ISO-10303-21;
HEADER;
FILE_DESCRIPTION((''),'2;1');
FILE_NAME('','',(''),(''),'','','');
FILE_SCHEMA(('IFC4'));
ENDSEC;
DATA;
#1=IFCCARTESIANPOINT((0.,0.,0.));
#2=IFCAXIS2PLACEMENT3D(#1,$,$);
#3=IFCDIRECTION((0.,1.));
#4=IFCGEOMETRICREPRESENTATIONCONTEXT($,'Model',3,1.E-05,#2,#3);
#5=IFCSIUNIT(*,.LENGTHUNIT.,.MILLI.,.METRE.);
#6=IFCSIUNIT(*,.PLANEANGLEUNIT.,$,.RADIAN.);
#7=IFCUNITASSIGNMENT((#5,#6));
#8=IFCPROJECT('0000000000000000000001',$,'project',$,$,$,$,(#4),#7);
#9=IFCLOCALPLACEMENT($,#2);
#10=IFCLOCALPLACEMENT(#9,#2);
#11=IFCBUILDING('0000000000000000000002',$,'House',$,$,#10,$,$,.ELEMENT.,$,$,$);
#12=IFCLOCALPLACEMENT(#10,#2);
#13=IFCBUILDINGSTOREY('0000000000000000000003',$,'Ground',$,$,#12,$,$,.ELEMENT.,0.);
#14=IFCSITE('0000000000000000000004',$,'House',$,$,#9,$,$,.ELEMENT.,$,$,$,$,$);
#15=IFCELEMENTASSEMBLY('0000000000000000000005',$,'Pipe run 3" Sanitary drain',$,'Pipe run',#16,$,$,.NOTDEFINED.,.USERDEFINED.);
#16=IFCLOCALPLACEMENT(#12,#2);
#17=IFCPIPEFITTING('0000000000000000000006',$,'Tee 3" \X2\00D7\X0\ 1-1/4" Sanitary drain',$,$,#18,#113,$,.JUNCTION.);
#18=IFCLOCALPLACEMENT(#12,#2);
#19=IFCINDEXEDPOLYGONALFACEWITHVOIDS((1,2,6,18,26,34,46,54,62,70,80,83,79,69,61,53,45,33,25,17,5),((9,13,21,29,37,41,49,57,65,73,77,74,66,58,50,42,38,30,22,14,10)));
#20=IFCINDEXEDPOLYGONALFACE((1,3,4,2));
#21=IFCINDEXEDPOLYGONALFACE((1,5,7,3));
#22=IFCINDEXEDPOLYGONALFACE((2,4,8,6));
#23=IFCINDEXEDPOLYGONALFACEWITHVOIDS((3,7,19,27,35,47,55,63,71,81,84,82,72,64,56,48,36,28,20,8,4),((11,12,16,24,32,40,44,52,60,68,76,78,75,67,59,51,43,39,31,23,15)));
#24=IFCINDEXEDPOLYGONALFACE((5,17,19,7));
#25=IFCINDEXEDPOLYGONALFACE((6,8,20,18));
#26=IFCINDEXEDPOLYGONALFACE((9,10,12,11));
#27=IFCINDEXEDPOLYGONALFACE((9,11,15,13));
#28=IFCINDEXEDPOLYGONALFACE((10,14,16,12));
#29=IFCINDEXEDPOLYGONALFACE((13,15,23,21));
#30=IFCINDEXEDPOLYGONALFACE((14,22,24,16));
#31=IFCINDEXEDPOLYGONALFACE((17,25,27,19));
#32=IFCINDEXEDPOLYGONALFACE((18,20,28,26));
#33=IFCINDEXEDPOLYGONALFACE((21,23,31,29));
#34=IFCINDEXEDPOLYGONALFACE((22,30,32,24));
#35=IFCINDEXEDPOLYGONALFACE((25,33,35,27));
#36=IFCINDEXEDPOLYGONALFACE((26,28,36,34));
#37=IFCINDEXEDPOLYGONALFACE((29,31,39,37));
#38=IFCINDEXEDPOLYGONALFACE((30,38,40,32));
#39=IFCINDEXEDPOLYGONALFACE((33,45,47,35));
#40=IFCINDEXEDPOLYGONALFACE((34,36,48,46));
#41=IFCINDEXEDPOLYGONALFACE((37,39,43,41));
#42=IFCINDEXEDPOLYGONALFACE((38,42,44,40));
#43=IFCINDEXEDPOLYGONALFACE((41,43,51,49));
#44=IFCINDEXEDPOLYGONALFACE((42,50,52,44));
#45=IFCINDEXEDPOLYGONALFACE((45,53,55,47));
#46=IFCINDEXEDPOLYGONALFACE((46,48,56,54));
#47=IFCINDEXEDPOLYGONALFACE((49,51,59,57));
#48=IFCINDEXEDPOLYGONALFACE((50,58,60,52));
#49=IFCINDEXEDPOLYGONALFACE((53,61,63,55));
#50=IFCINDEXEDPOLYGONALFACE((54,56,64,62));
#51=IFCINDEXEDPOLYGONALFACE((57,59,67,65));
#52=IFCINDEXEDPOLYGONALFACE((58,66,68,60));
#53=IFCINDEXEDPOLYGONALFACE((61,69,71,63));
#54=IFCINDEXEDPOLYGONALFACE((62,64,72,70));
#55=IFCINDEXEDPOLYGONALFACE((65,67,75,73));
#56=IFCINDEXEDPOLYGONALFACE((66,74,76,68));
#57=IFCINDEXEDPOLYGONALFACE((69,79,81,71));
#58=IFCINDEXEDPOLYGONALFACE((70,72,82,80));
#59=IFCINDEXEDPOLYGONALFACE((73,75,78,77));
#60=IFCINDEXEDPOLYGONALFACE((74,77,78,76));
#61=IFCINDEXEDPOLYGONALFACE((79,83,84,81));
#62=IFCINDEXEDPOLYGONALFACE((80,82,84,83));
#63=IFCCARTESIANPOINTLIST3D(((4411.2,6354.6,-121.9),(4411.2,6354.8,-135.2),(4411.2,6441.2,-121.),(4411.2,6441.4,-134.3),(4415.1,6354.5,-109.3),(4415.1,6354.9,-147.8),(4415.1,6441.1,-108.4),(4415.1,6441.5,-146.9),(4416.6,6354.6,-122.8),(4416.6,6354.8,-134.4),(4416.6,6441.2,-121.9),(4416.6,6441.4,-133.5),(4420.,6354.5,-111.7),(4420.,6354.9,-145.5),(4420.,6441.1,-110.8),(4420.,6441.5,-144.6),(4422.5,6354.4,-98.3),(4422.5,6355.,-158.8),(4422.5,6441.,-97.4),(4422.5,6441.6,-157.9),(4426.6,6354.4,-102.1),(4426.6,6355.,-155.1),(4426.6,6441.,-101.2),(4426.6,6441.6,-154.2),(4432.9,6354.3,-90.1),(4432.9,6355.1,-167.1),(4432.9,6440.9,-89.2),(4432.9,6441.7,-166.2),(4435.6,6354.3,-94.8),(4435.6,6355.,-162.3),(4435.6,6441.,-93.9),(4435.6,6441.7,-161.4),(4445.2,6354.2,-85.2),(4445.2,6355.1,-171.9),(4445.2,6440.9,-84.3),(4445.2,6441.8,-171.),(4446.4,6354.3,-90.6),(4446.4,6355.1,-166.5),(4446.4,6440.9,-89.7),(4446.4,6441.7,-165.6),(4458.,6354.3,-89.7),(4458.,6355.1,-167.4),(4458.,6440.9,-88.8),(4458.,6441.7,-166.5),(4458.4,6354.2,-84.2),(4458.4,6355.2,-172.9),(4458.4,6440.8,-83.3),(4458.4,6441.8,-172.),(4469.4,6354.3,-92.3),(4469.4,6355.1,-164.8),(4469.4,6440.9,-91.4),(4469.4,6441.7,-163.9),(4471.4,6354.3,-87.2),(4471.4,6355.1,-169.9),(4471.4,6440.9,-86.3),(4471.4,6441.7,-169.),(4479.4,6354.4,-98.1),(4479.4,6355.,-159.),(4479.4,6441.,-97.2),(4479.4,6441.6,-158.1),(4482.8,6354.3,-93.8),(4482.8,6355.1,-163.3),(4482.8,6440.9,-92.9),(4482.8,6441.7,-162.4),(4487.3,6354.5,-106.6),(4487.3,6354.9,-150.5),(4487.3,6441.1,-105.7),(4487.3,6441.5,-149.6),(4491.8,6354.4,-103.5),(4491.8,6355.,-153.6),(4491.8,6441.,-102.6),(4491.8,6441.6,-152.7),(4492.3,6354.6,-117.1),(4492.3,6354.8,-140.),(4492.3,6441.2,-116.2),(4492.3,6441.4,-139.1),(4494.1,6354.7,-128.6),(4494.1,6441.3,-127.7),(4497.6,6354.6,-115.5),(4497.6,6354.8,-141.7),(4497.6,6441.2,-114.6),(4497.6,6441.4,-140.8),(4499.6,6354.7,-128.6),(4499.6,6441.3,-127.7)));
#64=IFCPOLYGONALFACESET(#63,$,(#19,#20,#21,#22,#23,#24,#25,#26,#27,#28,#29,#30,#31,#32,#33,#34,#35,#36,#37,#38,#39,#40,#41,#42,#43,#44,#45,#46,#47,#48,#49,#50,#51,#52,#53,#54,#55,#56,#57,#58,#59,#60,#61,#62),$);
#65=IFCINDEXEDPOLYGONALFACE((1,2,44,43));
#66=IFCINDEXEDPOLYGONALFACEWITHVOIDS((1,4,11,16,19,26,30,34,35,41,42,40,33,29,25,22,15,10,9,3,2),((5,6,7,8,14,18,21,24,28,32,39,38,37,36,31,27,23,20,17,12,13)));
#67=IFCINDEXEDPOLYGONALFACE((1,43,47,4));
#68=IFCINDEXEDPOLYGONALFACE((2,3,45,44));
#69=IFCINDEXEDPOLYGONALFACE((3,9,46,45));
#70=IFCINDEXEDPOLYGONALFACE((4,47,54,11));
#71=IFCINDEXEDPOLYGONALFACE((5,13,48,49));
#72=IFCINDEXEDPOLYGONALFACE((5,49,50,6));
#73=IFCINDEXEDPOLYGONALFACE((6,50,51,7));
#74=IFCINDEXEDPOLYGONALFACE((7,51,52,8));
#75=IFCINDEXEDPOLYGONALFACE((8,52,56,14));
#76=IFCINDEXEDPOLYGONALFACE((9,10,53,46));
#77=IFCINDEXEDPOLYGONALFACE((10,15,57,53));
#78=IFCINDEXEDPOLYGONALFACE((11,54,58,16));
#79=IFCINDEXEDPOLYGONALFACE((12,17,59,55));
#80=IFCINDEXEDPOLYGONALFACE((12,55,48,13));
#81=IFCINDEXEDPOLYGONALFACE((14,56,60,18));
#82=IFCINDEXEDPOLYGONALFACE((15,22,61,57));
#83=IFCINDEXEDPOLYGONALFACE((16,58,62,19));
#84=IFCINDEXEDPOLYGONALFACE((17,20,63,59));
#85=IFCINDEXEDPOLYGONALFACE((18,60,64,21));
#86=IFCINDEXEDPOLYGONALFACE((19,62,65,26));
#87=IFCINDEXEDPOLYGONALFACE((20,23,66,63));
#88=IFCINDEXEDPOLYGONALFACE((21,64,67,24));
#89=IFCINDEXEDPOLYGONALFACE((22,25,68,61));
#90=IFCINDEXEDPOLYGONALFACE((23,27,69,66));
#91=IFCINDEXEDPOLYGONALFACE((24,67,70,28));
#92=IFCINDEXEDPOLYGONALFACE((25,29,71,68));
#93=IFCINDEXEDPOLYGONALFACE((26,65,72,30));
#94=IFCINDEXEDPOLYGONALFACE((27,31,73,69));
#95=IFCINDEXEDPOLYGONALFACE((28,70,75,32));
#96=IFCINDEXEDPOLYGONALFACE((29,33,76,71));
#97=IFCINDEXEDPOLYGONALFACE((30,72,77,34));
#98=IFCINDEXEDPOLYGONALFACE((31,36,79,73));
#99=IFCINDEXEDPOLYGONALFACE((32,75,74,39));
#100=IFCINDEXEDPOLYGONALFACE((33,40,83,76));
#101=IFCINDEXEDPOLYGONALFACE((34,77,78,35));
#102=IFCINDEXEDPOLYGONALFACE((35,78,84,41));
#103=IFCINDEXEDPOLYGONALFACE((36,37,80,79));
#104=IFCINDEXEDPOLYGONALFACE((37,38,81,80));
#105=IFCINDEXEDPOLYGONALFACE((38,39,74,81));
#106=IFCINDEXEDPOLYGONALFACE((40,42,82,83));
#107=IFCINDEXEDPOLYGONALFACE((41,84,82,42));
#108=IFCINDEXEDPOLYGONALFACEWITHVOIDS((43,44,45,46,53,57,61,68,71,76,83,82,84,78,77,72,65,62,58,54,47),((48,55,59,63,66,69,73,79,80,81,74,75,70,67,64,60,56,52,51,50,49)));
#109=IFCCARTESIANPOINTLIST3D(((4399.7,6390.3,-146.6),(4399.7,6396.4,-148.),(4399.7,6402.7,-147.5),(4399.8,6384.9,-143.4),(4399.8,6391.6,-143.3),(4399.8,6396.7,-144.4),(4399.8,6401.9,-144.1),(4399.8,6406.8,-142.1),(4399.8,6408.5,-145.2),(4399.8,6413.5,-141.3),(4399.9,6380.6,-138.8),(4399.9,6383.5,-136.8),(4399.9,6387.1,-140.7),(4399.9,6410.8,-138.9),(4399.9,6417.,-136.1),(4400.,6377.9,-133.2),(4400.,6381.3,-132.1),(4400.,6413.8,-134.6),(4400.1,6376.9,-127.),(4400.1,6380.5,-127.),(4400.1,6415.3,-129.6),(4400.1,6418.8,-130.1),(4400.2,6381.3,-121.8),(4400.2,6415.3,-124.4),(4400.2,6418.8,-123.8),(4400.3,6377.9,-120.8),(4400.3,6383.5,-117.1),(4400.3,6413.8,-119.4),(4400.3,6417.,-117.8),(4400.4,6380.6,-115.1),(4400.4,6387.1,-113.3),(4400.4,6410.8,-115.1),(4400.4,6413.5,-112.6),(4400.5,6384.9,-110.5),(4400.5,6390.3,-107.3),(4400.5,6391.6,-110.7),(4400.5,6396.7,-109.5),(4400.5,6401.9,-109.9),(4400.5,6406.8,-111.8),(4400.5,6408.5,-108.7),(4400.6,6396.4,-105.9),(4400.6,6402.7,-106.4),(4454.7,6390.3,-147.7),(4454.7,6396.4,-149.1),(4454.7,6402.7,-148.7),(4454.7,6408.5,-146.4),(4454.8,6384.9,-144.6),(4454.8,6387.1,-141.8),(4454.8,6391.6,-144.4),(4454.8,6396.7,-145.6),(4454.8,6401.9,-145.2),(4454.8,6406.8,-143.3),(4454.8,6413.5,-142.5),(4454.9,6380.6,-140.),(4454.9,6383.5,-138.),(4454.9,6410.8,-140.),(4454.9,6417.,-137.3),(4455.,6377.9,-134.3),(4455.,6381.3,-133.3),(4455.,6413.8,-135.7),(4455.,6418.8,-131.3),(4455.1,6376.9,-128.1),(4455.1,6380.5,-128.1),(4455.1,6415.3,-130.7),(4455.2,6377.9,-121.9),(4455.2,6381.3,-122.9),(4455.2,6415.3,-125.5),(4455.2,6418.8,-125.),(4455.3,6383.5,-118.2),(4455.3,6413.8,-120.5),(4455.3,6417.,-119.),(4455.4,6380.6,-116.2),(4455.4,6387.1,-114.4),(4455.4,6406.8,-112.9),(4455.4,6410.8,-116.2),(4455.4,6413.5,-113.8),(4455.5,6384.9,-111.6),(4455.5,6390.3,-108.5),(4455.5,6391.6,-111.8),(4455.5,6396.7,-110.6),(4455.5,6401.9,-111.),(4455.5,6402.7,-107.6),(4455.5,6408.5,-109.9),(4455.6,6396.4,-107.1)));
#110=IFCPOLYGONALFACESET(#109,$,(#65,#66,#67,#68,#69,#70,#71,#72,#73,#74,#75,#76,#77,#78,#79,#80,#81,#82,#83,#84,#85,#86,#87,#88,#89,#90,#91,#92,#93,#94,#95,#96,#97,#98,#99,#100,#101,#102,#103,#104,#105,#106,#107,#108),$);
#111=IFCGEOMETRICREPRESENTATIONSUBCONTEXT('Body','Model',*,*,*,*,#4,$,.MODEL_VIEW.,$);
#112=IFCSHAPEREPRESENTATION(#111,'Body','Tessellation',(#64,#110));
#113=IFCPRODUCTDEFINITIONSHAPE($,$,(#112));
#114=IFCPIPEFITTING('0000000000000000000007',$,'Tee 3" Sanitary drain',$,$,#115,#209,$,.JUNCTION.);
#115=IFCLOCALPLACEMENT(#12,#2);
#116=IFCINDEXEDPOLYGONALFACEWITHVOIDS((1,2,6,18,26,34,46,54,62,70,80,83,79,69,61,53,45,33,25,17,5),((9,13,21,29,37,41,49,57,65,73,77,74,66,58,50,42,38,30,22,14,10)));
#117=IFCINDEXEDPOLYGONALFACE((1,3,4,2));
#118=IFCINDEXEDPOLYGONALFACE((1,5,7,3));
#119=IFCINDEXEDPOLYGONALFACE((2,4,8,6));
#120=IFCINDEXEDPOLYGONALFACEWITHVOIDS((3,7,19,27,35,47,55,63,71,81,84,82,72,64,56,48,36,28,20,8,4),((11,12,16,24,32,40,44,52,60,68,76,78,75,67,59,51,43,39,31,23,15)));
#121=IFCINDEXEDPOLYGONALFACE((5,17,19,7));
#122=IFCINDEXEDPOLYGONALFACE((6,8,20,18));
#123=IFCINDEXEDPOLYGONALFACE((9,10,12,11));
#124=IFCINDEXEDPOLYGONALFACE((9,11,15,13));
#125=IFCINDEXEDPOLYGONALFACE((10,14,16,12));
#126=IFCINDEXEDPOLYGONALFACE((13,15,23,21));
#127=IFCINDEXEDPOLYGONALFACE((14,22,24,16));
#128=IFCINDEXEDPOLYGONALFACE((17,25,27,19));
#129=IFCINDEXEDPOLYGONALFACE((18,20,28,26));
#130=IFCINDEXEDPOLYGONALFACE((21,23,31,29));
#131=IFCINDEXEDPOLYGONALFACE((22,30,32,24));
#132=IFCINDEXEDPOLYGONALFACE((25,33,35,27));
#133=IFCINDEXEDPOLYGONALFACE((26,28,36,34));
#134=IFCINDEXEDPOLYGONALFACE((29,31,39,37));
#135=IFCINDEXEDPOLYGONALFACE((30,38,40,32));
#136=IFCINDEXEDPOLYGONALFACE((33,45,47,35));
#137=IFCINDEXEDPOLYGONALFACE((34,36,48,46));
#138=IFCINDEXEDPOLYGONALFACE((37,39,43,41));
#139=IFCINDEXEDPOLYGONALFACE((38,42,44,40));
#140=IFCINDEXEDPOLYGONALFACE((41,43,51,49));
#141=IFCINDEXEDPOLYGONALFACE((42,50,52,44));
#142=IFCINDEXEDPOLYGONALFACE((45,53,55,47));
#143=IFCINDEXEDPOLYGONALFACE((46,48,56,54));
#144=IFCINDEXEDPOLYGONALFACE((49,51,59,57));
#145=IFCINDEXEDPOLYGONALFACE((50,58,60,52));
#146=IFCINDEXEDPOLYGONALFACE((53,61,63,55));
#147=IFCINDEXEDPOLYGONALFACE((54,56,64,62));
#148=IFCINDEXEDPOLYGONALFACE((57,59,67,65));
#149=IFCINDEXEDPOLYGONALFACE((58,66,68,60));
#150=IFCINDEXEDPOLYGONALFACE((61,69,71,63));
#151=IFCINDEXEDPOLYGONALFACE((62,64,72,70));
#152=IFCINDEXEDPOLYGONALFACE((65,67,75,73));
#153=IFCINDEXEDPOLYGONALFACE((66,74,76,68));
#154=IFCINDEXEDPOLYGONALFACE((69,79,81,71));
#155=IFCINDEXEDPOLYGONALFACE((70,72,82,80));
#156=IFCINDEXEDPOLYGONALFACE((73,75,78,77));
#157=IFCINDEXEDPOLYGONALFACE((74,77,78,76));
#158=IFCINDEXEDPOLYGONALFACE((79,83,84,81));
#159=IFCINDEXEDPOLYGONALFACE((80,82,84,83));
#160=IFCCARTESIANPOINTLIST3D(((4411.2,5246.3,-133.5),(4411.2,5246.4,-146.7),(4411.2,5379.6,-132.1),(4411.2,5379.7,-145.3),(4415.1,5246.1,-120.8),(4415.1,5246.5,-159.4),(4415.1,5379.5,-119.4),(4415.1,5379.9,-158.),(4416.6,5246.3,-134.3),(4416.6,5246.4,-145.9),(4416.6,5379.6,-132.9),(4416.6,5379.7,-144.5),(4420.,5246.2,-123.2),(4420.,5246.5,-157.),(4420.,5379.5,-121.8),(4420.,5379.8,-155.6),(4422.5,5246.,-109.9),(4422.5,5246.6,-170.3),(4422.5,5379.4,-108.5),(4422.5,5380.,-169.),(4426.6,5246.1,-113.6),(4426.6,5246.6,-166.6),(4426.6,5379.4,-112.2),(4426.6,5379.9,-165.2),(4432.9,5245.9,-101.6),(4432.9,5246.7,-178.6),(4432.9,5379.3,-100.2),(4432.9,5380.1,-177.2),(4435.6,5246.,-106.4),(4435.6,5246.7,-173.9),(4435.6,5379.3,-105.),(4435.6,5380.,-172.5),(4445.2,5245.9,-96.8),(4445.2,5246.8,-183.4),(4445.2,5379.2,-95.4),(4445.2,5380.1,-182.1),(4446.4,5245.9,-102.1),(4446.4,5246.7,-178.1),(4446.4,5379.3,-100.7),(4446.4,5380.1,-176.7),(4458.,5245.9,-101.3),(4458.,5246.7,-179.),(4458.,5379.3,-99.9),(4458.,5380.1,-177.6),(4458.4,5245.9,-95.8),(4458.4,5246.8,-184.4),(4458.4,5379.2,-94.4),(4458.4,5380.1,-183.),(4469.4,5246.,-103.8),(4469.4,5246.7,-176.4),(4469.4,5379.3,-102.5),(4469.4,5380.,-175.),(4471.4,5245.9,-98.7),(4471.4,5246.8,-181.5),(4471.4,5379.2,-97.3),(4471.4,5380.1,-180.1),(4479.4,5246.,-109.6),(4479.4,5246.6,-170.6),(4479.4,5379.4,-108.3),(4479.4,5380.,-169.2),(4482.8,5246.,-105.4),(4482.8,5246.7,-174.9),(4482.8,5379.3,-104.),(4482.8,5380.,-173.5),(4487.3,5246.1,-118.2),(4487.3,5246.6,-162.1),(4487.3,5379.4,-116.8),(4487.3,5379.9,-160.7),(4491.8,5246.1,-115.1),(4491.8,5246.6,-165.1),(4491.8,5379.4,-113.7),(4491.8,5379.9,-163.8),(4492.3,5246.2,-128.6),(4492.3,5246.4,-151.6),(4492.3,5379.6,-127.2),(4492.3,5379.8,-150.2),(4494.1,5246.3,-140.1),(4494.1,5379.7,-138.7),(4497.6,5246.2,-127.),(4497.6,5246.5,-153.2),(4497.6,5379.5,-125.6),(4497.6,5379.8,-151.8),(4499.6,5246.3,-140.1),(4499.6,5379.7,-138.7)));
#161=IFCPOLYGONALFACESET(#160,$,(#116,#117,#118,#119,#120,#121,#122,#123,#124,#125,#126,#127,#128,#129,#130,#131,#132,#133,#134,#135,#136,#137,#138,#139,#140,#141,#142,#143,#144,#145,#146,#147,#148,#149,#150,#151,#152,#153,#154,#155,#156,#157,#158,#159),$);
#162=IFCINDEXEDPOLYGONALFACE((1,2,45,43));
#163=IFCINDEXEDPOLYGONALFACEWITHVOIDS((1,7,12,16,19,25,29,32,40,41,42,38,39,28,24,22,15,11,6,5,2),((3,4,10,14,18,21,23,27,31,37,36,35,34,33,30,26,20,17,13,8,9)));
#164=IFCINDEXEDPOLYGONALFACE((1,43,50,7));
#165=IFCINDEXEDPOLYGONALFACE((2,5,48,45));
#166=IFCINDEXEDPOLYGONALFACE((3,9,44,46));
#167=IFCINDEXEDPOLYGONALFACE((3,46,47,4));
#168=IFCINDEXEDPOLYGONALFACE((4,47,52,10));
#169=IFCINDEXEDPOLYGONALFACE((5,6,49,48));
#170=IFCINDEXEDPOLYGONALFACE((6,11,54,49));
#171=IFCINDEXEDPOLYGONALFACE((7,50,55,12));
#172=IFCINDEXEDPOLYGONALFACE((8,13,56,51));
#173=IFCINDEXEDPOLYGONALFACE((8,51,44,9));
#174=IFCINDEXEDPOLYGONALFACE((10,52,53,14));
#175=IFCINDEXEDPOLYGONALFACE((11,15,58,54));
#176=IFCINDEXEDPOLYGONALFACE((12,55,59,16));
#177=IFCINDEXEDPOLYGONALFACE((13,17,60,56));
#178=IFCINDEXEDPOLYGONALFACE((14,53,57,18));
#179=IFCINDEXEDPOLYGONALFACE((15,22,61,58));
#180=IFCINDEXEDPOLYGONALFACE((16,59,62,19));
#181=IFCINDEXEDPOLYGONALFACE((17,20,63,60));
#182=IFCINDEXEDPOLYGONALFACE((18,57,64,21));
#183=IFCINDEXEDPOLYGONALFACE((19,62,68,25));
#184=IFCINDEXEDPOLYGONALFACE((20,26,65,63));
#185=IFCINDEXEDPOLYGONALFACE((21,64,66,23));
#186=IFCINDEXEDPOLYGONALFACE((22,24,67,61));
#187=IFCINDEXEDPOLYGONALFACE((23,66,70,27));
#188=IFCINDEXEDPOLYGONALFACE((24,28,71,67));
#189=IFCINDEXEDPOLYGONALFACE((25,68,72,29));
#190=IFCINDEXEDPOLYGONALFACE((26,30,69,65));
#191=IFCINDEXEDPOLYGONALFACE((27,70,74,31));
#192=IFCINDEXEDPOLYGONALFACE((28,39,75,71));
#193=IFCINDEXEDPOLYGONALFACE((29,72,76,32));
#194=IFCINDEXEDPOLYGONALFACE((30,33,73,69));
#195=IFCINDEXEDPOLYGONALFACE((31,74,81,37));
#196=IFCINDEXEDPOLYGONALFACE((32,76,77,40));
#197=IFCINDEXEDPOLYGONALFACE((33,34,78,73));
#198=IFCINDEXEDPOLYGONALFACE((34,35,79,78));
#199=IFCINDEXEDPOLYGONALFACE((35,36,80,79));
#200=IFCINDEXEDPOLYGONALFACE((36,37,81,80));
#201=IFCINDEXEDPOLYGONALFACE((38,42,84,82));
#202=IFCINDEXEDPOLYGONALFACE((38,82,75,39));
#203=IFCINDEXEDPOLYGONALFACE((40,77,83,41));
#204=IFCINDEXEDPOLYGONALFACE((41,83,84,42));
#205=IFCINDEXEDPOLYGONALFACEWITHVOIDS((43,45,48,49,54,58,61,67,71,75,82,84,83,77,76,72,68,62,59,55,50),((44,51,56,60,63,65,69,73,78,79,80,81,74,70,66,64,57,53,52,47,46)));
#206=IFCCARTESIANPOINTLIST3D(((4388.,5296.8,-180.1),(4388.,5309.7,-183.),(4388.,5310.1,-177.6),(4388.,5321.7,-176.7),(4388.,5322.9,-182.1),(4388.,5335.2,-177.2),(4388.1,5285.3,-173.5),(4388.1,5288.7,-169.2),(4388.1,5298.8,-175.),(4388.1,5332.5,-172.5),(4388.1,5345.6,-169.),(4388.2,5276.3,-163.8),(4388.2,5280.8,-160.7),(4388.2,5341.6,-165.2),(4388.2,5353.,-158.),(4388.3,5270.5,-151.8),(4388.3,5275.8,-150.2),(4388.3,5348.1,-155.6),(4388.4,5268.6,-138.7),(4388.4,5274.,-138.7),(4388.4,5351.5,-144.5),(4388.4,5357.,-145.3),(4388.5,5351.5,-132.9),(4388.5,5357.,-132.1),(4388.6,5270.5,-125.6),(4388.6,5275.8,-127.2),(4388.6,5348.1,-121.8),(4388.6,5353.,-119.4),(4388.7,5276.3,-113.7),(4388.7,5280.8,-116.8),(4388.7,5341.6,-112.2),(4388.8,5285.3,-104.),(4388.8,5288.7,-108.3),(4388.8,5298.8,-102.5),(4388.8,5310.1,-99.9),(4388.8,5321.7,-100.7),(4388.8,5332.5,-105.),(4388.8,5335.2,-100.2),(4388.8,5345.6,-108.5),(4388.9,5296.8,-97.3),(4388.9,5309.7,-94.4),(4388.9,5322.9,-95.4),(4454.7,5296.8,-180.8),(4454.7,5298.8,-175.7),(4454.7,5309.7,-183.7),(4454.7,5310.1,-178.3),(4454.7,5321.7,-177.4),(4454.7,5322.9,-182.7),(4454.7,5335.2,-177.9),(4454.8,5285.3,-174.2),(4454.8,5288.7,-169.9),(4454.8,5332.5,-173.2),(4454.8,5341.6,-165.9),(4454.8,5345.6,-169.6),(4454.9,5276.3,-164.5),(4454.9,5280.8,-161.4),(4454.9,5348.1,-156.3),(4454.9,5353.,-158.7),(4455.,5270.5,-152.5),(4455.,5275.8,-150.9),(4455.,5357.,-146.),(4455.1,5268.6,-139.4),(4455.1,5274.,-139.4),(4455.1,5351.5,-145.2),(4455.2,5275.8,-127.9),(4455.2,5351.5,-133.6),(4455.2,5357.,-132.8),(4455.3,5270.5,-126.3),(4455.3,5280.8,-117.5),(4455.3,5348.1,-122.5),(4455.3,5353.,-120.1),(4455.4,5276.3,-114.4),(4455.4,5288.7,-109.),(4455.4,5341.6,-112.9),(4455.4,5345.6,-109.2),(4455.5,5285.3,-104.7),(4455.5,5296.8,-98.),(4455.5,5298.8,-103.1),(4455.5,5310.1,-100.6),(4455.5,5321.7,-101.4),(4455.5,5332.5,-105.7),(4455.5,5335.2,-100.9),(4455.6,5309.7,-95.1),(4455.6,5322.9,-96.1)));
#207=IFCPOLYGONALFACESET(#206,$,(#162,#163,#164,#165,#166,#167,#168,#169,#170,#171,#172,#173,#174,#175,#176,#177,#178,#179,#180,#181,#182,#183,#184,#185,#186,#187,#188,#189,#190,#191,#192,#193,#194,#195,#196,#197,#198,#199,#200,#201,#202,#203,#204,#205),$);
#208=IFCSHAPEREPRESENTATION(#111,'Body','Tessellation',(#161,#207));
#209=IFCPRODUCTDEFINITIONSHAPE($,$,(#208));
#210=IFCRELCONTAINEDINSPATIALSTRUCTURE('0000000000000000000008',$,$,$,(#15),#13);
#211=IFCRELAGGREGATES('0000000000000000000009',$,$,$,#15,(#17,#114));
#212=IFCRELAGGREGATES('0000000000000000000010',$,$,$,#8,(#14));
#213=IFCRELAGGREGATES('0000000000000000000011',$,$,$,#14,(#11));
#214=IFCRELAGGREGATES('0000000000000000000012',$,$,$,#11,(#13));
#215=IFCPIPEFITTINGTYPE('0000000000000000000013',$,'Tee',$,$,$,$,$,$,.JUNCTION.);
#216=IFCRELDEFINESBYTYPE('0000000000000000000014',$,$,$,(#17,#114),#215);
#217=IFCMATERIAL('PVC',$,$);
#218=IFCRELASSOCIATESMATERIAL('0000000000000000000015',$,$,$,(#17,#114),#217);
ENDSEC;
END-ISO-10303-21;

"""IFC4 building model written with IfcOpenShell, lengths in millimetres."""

from ifc_helpers import new_model, si_unit, direction, frame, origin, origin_with_axes, origin_2d, place, context, subcontext, project, spatial, hollow_circle, extrude, material, type_object, element, aggregate, save


model = new_model("IFC4")

# Units and contexts
model_context = context("Model", 3, precision=1e-05, world=origin(), true_north=direction((0.0, 1.0)))
body_context = subcontext(model_context, "Body", "Model", "MODEL_VIEW")
ifc_project = project(units=[si_unit("LENGTHUNIT", "METRE", prefix="MILLI"), si_unit("PLANEANGLEUNIT", "RADIAN")], contexts=[model_context])

# Site, building, storey
site_placement = place(None, origin())
site = spatial("IfcSite", under=ifc_project, at=site_placement, Name="House", CompositionType="ELEMENT")
building_placement = place(site_placement, origin())
building = spatial("IfcBuilding", under=site, at=building_placement, Name="House", CompositionType="ELEMENT")
storey_placement = place(building_placement, origin())
storey = spatial("IfcBuildingStorey", under=building, at=storey_placement, Name="Ground", CompositionType="ELEMENT", Elevation=0.0)

# Element assembly
ifc_material = material(Name="PVC")
assembly_1_placement = place(storey_placement, origin_with_axes())
assembly_1 = element("IfcElementAssembly", 1, at=assembly_1_placement, inside=storey, Name="Pipe run 3\" Sanitary drain", ObjectType="Pipe run", AssemblyPlace="NOTDEFINED", PredefinedType="USERDEFINED")

# Pipe fittings
pipe_fitting_type_1 = type_object("IfcPipeFittingType", Name="Tee", PredefinedType="JUNCTION")
pipe_fitting_1_placement = place(storey_placement, origin_with_axes())
pipe_fitting_1 = element("IfcPipeFitting", 2, at=pipe_fitting_1_placement, type_object=pipe_fitting_type_1, material=ifc_material, Name="Tee 3\" × 1-1/4\" Sanitary drain", PredefinedType="JUNCTION", context=body_context, shape_type="SweptSolid", body=[
    extrude(hollow_circle(Radius=44.5, WallThickness=5.5, at=origin_2d()), frame((4455.1, 6441.3, -127.7), z_axis=(0.0, -0.999946, -0.010416), x_axis=(1.0, 0.0, 0.0)), (0.0, 0.0, 1.0), 86.6),
    extrude(hollow_circle(Radius=21.1, WallThickness=3.6, at=origin_2d()), frame((4455.1, 6398.0, -128.1), z_axis=(-0.999783, 0.0, 0.020829), x_axis=(0.0, -1.0, 0.0)), (0.0, 0.0, 1.0), 55.0),
])
pipe_fitting_2_placement = place(storey_placement, origin_with_axes())
pipe_fitting_2 = element("IfcPipeFitting", 3, at=pipe_fitting_2_placement, type_object=pipe_fitting_type_1, material=ifc_material, Name="Tee 3\" Sanitary drain", PredefinedType="JUNCTION", context=body_context, shape_type="SweptSolid", body=[
    extrude(hollow_circle(Radius=44.5, WallThickness=5.5, at=origin_2d()), frame((4455.1, 5379.7, -138.7), z_axis=(0.0, -0.999946, -0.010416), x_axis=(1.0, 0.0, 0.0)), (0.0, 0.0, 1.0), 133.3),
    extrude(hollow_circle(Radius=44.5, WallThickness=5.5, at=origin_2d()), frame((4455.1, 5313.0, -139.4), z_axis=(-0.999946, 0.0, 0.010416), x_axis=(0.0, -1.0, 0.0)), (0.0, 0.0, 1.0), 66.7),
])
aggregate(assembly_1, [pipe_fitting_1, pipe_fitting_2])

save(model, "model.ifc")
